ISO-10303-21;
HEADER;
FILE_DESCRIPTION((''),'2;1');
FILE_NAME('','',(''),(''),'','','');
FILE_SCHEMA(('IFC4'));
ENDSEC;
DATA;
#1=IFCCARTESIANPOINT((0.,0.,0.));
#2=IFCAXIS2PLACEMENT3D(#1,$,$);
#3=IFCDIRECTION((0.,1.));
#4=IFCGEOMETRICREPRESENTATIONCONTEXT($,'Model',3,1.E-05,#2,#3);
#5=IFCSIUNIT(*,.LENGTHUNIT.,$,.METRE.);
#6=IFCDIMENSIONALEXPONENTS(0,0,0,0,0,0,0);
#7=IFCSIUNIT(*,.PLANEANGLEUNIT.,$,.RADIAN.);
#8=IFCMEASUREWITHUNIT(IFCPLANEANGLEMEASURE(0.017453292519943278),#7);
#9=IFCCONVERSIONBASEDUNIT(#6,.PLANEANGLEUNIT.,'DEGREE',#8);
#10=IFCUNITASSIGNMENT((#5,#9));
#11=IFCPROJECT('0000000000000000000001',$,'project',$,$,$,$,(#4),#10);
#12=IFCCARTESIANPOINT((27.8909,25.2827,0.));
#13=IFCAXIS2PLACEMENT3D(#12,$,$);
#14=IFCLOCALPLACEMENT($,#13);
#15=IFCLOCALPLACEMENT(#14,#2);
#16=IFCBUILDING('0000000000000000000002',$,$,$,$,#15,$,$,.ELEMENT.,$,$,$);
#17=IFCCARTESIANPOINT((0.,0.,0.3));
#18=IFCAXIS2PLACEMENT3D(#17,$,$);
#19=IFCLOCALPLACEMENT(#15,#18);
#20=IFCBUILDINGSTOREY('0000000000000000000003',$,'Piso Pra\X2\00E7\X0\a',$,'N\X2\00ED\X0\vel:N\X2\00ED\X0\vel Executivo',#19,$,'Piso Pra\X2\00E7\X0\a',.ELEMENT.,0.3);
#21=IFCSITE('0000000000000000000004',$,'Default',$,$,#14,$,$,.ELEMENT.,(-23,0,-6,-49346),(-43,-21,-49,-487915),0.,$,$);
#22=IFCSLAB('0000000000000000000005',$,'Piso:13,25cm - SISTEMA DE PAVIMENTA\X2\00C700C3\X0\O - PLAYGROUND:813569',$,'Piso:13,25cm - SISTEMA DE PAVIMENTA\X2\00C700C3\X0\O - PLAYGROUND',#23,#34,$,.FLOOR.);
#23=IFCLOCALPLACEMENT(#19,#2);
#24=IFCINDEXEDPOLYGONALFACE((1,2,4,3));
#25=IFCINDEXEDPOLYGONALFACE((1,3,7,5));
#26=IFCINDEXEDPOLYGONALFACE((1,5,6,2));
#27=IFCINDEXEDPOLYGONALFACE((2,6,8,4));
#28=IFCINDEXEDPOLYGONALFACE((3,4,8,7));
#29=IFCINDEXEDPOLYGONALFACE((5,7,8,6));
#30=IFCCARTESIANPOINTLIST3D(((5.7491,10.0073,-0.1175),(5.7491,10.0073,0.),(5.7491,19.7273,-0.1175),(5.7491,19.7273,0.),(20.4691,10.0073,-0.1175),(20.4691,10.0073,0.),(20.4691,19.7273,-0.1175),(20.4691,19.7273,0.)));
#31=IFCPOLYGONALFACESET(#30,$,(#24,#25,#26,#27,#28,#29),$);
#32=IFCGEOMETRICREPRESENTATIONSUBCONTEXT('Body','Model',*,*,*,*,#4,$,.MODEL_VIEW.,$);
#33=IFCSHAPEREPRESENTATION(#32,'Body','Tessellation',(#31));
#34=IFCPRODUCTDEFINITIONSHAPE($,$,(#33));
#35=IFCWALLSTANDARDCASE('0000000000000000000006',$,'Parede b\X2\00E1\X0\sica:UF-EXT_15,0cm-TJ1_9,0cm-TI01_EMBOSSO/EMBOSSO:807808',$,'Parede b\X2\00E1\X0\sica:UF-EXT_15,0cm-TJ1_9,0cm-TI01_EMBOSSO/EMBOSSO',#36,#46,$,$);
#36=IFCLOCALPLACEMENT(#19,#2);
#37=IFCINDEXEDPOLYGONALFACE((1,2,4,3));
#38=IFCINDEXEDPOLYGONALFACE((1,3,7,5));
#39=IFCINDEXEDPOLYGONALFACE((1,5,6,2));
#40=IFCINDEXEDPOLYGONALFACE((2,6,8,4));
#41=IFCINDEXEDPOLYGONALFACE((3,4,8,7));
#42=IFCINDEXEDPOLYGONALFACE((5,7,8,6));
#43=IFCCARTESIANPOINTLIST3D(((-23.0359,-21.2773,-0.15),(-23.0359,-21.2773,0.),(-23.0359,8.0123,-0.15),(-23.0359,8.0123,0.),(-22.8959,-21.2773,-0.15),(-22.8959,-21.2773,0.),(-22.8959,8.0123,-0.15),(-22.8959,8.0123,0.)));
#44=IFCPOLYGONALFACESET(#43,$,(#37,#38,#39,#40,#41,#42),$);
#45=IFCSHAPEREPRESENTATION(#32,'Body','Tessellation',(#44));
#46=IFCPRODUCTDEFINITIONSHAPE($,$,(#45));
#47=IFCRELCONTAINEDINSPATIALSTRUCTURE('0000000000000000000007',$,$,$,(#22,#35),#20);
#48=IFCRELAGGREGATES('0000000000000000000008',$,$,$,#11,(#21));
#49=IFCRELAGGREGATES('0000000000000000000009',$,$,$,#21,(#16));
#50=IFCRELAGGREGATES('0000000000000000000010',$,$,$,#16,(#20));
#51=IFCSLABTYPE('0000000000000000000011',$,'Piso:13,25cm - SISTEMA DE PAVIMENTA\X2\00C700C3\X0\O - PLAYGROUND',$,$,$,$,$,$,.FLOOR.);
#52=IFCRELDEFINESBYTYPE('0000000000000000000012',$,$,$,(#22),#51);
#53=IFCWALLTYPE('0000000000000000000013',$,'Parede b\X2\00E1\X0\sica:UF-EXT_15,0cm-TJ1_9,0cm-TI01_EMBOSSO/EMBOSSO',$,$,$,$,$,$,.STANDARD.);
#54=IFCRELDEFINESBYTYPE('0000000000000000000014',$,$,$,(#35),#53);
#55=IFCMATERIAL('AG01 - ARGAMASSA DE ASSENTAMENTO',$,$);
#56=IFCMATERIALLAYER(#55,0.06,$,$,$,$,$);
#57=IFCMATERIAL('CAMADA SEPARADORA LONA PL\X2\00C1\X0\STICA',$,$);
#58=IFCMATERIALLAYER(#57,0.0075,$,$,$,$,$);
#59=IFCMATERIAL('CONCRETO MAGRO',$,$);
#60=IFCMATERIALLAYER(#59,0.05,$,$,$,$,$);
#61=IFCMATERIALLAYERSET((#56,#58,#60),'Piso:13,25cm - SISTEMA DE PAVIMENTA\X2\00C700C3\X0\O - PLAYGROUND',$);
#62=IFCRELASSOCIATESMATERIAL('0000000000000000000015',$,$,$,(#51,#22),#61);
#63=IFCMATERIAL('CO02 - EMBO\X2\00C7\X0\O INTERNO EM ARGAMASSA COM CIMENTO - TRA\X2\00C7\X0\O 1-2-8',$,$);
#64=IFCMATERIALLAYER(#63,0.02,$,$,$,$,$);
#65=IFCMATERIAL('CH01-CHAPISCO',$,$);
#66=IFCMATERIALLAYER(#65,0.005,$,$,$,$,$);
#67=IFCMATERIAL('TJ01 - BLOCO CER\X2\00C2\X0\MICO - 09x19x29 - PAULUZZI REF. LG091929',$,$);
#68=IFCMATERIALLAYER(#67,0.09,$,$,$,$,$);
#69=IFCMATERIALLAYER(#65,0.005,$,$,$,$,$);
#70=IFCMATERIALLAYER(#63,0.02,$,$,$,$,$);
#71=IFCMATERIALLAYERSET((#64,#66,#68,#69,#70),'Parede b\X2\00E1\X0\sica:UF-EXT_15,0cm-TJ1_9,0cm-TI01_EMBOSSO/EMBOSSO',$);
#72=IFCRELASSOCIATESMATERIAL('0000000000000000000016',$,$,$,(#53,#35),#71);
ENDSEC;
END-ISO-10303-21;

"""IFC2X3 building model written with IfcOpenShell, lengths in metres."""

from ifc_helpers import new_model, entity, si_unit, converted_unit, direction, frame, frame_2d, origin, place, context, subcontext, project, spatial, rectangle, extrude, material, layer, layer_set, layer_usage, type_object, element, save


model = new_model("IFC2X3")

# Units and contexts
model_context = context("Model", 3, precision=1e-05, world=origin(), true_north=direction((0.0, 1.0)))
body_context = subcontext(model_context, "Body", "Model", "MODEL_VIEW")
ifc_project = project(units=[si_unit("LENGTHUNIT", "METRE"), converted_unit("PLANEANGLEUNIT", "DEGREE", entity("IfcPlaneAngleMeasure", 0.017453292519943278), si_unit("PLANEANGLEUNIT", "RADIAN"), dimensions=[0, 0, 0, 0, 0, 0, 0])], contexts=[model_context])

# Site, building, storey
site_placement = place(None, frame((27.8909, 25.2827, 0.0)))
site = spatial("IfcSite", under=ifc_project, at=site_placement, Name="Default", CompositionType="ELEMENT", RefLatitude=(-23, 0, -6, -49346), RefLongitude=(-43, -21, -49, -487915), RefElevation=0.0)
building_placement = place(site_placement, origin())
building = spatial("IfcBuilding", under=site, at=building_placement, CompositionType="ELEMENT")
storey_placement = place(building_placement, frame((0.0, 0.0, 0.3)))
storey = spatial("IfcBuildingStorey", under=building, at=storey_placement, Name="Piso Praça", ObjectType="Nível:Nível Executivo", LongName="Piso Praça", CompositionType="ELEMENT", Elevation=0.3)

# Shared definitions
ifc_material_1 = material(Name="CONCRETO MAGRO")

# Slab
ifc_material_2 = material(Name="AG01 - ARGAMASSA DE ASSENTAMENTO")
ifc_layer_1 = layer(ifc_material_2, 0.06)
ifc_material_3 = material(Name="CAMADA SEPARADORA LONA PLÁSTICA")
ifc_layer_2 = layer(ifc_material_3, 0.0075)
ifc_layer_3 = layer(ifc_material_1, 0.05)
ifc_layer_set_1 = layer_set([ifc_layer_1, ifc_layer_2, ifc_layer_3], Name="Piso:13,25cm - SISTEMA DE PAVIMENTAÇÃO - PLAYGROUND")
ifc_layer_usage_1 = layer_usage(ifc_layer_set_1, "AXIS3", "POSITIVE", 0.0)
slab_type_1 = type_object("IfcSlabType", Name="Piso:13,25cm - SISTEMA DE PAVIMENTAÇÃO - PLAYGROUND", PredefinedType="FLOOR", material=ifc_layer_set_1)
slab_1_placement = place(storey_placement, origin())
element("IfcSlab", 1, at=slab_1_placement, inside=storey, type_object=slab_type_1, material=ifc_layer_usage_1, Name="Piso:13,25cm - SISTEMA DE PAVIMENTAÇÃO - PLAYGROUND:813569", ObjectType="Piso:13,25cm - SISTEMA DE PAVIMENTAÇÃO - PLAYGROUND", PredefinedType="FLOOR", context=body_context, shape_type="SweptSolid", body=[
    extrude(rectangle(XDim=9.72, YDim=14.72, at=frame_2d((0.0, 0.0), x_axis=(1.0, 0.0))), frame((13.1091, 14.8673, 0.0), z_axis=(0.0, 0.0, -1.0), x_axis=(0.0, 1.0, 0.0)), (0.0, 0.0, 1.0), 0.1175),
])

# Wall
ifc_material_4 = material(Name="CO02 - EMBOÇO INTERNO EM ARGAMASSA COM CIMENTO - TRAÇO 1-2-8")
ifc_layer_4 = layer(ifc_material_4, 0.02)
ifc_material_5 = material(Name="CH01-CHAPISCO")
ifc_layer_5 = layer(ifc_material_5, 0.005)
ifc_material_6 = material(Name="TJ01 - BLOCO CERÂMICO - 09x19x29 - PAULUZZI REF. LG091929")
ifc_layer_6 = layer(ifc_material_6, 0.09)
ifc_layer_7 = layer(ifc_material_5, 0.005)
ifc_layer_8 = layer(ifc_material_4, 0.02)
ifc_layer_set_2 = layer_set([ifc_layer_4, ifc_layer_5, ifc_layer_6, ifc_layer_7, ifc_layer_8], Name="Parede básica:UF-EXT_15,0cm-TJ1_9,0cm-TI01_EMBOSSO/EMBOSSO")
ifc_layer_usage_2 = layer_usage(ifc_layer_set_2, "AXIS2", "NEGATIVE", 0.07)
wall_type = type_object("IfcWallType", Name="Parede básica:UF-EXT_15,0cm-TJ1_9,0cm-TI01_EMBOSSO/EMBOSSO", PredefinedType="STANDARD", material=ifc_layer_set_2)
wall_placement = place(storey_placement, frame((-22.9659, -21.2773, -0.15), z_axis=(0.0, 0.0, 1.0), x_axis=(0.0, 1.0, 0.0)))
element("IfcWallStandardCase", 2, at=wall_placement, inside=storey, type_object=wall_type, material=ifc_layer_usage_2, Name="Parede básica:UF-EXT_15,0cm-TJ1_9,0cm-TI01_EMBOSSO/EMBOSSO:807808", ObjectType="Parede básica:UF-EXT_15,0cm-TJ1_9,0cm-TI01_EMBOSSO/EMBOSSO", context=body_context, shape_type="SweptSolid", body=[
    extrude(rectangle(XDim=29.2896, YDim=0.14, at=frame_2d((14.6448, 0.0), x_axis=(-1.0, 0.0))), origin(), (0.0, 0.0, 1.0), 0.15),
])

save(model, "model.ifc")
